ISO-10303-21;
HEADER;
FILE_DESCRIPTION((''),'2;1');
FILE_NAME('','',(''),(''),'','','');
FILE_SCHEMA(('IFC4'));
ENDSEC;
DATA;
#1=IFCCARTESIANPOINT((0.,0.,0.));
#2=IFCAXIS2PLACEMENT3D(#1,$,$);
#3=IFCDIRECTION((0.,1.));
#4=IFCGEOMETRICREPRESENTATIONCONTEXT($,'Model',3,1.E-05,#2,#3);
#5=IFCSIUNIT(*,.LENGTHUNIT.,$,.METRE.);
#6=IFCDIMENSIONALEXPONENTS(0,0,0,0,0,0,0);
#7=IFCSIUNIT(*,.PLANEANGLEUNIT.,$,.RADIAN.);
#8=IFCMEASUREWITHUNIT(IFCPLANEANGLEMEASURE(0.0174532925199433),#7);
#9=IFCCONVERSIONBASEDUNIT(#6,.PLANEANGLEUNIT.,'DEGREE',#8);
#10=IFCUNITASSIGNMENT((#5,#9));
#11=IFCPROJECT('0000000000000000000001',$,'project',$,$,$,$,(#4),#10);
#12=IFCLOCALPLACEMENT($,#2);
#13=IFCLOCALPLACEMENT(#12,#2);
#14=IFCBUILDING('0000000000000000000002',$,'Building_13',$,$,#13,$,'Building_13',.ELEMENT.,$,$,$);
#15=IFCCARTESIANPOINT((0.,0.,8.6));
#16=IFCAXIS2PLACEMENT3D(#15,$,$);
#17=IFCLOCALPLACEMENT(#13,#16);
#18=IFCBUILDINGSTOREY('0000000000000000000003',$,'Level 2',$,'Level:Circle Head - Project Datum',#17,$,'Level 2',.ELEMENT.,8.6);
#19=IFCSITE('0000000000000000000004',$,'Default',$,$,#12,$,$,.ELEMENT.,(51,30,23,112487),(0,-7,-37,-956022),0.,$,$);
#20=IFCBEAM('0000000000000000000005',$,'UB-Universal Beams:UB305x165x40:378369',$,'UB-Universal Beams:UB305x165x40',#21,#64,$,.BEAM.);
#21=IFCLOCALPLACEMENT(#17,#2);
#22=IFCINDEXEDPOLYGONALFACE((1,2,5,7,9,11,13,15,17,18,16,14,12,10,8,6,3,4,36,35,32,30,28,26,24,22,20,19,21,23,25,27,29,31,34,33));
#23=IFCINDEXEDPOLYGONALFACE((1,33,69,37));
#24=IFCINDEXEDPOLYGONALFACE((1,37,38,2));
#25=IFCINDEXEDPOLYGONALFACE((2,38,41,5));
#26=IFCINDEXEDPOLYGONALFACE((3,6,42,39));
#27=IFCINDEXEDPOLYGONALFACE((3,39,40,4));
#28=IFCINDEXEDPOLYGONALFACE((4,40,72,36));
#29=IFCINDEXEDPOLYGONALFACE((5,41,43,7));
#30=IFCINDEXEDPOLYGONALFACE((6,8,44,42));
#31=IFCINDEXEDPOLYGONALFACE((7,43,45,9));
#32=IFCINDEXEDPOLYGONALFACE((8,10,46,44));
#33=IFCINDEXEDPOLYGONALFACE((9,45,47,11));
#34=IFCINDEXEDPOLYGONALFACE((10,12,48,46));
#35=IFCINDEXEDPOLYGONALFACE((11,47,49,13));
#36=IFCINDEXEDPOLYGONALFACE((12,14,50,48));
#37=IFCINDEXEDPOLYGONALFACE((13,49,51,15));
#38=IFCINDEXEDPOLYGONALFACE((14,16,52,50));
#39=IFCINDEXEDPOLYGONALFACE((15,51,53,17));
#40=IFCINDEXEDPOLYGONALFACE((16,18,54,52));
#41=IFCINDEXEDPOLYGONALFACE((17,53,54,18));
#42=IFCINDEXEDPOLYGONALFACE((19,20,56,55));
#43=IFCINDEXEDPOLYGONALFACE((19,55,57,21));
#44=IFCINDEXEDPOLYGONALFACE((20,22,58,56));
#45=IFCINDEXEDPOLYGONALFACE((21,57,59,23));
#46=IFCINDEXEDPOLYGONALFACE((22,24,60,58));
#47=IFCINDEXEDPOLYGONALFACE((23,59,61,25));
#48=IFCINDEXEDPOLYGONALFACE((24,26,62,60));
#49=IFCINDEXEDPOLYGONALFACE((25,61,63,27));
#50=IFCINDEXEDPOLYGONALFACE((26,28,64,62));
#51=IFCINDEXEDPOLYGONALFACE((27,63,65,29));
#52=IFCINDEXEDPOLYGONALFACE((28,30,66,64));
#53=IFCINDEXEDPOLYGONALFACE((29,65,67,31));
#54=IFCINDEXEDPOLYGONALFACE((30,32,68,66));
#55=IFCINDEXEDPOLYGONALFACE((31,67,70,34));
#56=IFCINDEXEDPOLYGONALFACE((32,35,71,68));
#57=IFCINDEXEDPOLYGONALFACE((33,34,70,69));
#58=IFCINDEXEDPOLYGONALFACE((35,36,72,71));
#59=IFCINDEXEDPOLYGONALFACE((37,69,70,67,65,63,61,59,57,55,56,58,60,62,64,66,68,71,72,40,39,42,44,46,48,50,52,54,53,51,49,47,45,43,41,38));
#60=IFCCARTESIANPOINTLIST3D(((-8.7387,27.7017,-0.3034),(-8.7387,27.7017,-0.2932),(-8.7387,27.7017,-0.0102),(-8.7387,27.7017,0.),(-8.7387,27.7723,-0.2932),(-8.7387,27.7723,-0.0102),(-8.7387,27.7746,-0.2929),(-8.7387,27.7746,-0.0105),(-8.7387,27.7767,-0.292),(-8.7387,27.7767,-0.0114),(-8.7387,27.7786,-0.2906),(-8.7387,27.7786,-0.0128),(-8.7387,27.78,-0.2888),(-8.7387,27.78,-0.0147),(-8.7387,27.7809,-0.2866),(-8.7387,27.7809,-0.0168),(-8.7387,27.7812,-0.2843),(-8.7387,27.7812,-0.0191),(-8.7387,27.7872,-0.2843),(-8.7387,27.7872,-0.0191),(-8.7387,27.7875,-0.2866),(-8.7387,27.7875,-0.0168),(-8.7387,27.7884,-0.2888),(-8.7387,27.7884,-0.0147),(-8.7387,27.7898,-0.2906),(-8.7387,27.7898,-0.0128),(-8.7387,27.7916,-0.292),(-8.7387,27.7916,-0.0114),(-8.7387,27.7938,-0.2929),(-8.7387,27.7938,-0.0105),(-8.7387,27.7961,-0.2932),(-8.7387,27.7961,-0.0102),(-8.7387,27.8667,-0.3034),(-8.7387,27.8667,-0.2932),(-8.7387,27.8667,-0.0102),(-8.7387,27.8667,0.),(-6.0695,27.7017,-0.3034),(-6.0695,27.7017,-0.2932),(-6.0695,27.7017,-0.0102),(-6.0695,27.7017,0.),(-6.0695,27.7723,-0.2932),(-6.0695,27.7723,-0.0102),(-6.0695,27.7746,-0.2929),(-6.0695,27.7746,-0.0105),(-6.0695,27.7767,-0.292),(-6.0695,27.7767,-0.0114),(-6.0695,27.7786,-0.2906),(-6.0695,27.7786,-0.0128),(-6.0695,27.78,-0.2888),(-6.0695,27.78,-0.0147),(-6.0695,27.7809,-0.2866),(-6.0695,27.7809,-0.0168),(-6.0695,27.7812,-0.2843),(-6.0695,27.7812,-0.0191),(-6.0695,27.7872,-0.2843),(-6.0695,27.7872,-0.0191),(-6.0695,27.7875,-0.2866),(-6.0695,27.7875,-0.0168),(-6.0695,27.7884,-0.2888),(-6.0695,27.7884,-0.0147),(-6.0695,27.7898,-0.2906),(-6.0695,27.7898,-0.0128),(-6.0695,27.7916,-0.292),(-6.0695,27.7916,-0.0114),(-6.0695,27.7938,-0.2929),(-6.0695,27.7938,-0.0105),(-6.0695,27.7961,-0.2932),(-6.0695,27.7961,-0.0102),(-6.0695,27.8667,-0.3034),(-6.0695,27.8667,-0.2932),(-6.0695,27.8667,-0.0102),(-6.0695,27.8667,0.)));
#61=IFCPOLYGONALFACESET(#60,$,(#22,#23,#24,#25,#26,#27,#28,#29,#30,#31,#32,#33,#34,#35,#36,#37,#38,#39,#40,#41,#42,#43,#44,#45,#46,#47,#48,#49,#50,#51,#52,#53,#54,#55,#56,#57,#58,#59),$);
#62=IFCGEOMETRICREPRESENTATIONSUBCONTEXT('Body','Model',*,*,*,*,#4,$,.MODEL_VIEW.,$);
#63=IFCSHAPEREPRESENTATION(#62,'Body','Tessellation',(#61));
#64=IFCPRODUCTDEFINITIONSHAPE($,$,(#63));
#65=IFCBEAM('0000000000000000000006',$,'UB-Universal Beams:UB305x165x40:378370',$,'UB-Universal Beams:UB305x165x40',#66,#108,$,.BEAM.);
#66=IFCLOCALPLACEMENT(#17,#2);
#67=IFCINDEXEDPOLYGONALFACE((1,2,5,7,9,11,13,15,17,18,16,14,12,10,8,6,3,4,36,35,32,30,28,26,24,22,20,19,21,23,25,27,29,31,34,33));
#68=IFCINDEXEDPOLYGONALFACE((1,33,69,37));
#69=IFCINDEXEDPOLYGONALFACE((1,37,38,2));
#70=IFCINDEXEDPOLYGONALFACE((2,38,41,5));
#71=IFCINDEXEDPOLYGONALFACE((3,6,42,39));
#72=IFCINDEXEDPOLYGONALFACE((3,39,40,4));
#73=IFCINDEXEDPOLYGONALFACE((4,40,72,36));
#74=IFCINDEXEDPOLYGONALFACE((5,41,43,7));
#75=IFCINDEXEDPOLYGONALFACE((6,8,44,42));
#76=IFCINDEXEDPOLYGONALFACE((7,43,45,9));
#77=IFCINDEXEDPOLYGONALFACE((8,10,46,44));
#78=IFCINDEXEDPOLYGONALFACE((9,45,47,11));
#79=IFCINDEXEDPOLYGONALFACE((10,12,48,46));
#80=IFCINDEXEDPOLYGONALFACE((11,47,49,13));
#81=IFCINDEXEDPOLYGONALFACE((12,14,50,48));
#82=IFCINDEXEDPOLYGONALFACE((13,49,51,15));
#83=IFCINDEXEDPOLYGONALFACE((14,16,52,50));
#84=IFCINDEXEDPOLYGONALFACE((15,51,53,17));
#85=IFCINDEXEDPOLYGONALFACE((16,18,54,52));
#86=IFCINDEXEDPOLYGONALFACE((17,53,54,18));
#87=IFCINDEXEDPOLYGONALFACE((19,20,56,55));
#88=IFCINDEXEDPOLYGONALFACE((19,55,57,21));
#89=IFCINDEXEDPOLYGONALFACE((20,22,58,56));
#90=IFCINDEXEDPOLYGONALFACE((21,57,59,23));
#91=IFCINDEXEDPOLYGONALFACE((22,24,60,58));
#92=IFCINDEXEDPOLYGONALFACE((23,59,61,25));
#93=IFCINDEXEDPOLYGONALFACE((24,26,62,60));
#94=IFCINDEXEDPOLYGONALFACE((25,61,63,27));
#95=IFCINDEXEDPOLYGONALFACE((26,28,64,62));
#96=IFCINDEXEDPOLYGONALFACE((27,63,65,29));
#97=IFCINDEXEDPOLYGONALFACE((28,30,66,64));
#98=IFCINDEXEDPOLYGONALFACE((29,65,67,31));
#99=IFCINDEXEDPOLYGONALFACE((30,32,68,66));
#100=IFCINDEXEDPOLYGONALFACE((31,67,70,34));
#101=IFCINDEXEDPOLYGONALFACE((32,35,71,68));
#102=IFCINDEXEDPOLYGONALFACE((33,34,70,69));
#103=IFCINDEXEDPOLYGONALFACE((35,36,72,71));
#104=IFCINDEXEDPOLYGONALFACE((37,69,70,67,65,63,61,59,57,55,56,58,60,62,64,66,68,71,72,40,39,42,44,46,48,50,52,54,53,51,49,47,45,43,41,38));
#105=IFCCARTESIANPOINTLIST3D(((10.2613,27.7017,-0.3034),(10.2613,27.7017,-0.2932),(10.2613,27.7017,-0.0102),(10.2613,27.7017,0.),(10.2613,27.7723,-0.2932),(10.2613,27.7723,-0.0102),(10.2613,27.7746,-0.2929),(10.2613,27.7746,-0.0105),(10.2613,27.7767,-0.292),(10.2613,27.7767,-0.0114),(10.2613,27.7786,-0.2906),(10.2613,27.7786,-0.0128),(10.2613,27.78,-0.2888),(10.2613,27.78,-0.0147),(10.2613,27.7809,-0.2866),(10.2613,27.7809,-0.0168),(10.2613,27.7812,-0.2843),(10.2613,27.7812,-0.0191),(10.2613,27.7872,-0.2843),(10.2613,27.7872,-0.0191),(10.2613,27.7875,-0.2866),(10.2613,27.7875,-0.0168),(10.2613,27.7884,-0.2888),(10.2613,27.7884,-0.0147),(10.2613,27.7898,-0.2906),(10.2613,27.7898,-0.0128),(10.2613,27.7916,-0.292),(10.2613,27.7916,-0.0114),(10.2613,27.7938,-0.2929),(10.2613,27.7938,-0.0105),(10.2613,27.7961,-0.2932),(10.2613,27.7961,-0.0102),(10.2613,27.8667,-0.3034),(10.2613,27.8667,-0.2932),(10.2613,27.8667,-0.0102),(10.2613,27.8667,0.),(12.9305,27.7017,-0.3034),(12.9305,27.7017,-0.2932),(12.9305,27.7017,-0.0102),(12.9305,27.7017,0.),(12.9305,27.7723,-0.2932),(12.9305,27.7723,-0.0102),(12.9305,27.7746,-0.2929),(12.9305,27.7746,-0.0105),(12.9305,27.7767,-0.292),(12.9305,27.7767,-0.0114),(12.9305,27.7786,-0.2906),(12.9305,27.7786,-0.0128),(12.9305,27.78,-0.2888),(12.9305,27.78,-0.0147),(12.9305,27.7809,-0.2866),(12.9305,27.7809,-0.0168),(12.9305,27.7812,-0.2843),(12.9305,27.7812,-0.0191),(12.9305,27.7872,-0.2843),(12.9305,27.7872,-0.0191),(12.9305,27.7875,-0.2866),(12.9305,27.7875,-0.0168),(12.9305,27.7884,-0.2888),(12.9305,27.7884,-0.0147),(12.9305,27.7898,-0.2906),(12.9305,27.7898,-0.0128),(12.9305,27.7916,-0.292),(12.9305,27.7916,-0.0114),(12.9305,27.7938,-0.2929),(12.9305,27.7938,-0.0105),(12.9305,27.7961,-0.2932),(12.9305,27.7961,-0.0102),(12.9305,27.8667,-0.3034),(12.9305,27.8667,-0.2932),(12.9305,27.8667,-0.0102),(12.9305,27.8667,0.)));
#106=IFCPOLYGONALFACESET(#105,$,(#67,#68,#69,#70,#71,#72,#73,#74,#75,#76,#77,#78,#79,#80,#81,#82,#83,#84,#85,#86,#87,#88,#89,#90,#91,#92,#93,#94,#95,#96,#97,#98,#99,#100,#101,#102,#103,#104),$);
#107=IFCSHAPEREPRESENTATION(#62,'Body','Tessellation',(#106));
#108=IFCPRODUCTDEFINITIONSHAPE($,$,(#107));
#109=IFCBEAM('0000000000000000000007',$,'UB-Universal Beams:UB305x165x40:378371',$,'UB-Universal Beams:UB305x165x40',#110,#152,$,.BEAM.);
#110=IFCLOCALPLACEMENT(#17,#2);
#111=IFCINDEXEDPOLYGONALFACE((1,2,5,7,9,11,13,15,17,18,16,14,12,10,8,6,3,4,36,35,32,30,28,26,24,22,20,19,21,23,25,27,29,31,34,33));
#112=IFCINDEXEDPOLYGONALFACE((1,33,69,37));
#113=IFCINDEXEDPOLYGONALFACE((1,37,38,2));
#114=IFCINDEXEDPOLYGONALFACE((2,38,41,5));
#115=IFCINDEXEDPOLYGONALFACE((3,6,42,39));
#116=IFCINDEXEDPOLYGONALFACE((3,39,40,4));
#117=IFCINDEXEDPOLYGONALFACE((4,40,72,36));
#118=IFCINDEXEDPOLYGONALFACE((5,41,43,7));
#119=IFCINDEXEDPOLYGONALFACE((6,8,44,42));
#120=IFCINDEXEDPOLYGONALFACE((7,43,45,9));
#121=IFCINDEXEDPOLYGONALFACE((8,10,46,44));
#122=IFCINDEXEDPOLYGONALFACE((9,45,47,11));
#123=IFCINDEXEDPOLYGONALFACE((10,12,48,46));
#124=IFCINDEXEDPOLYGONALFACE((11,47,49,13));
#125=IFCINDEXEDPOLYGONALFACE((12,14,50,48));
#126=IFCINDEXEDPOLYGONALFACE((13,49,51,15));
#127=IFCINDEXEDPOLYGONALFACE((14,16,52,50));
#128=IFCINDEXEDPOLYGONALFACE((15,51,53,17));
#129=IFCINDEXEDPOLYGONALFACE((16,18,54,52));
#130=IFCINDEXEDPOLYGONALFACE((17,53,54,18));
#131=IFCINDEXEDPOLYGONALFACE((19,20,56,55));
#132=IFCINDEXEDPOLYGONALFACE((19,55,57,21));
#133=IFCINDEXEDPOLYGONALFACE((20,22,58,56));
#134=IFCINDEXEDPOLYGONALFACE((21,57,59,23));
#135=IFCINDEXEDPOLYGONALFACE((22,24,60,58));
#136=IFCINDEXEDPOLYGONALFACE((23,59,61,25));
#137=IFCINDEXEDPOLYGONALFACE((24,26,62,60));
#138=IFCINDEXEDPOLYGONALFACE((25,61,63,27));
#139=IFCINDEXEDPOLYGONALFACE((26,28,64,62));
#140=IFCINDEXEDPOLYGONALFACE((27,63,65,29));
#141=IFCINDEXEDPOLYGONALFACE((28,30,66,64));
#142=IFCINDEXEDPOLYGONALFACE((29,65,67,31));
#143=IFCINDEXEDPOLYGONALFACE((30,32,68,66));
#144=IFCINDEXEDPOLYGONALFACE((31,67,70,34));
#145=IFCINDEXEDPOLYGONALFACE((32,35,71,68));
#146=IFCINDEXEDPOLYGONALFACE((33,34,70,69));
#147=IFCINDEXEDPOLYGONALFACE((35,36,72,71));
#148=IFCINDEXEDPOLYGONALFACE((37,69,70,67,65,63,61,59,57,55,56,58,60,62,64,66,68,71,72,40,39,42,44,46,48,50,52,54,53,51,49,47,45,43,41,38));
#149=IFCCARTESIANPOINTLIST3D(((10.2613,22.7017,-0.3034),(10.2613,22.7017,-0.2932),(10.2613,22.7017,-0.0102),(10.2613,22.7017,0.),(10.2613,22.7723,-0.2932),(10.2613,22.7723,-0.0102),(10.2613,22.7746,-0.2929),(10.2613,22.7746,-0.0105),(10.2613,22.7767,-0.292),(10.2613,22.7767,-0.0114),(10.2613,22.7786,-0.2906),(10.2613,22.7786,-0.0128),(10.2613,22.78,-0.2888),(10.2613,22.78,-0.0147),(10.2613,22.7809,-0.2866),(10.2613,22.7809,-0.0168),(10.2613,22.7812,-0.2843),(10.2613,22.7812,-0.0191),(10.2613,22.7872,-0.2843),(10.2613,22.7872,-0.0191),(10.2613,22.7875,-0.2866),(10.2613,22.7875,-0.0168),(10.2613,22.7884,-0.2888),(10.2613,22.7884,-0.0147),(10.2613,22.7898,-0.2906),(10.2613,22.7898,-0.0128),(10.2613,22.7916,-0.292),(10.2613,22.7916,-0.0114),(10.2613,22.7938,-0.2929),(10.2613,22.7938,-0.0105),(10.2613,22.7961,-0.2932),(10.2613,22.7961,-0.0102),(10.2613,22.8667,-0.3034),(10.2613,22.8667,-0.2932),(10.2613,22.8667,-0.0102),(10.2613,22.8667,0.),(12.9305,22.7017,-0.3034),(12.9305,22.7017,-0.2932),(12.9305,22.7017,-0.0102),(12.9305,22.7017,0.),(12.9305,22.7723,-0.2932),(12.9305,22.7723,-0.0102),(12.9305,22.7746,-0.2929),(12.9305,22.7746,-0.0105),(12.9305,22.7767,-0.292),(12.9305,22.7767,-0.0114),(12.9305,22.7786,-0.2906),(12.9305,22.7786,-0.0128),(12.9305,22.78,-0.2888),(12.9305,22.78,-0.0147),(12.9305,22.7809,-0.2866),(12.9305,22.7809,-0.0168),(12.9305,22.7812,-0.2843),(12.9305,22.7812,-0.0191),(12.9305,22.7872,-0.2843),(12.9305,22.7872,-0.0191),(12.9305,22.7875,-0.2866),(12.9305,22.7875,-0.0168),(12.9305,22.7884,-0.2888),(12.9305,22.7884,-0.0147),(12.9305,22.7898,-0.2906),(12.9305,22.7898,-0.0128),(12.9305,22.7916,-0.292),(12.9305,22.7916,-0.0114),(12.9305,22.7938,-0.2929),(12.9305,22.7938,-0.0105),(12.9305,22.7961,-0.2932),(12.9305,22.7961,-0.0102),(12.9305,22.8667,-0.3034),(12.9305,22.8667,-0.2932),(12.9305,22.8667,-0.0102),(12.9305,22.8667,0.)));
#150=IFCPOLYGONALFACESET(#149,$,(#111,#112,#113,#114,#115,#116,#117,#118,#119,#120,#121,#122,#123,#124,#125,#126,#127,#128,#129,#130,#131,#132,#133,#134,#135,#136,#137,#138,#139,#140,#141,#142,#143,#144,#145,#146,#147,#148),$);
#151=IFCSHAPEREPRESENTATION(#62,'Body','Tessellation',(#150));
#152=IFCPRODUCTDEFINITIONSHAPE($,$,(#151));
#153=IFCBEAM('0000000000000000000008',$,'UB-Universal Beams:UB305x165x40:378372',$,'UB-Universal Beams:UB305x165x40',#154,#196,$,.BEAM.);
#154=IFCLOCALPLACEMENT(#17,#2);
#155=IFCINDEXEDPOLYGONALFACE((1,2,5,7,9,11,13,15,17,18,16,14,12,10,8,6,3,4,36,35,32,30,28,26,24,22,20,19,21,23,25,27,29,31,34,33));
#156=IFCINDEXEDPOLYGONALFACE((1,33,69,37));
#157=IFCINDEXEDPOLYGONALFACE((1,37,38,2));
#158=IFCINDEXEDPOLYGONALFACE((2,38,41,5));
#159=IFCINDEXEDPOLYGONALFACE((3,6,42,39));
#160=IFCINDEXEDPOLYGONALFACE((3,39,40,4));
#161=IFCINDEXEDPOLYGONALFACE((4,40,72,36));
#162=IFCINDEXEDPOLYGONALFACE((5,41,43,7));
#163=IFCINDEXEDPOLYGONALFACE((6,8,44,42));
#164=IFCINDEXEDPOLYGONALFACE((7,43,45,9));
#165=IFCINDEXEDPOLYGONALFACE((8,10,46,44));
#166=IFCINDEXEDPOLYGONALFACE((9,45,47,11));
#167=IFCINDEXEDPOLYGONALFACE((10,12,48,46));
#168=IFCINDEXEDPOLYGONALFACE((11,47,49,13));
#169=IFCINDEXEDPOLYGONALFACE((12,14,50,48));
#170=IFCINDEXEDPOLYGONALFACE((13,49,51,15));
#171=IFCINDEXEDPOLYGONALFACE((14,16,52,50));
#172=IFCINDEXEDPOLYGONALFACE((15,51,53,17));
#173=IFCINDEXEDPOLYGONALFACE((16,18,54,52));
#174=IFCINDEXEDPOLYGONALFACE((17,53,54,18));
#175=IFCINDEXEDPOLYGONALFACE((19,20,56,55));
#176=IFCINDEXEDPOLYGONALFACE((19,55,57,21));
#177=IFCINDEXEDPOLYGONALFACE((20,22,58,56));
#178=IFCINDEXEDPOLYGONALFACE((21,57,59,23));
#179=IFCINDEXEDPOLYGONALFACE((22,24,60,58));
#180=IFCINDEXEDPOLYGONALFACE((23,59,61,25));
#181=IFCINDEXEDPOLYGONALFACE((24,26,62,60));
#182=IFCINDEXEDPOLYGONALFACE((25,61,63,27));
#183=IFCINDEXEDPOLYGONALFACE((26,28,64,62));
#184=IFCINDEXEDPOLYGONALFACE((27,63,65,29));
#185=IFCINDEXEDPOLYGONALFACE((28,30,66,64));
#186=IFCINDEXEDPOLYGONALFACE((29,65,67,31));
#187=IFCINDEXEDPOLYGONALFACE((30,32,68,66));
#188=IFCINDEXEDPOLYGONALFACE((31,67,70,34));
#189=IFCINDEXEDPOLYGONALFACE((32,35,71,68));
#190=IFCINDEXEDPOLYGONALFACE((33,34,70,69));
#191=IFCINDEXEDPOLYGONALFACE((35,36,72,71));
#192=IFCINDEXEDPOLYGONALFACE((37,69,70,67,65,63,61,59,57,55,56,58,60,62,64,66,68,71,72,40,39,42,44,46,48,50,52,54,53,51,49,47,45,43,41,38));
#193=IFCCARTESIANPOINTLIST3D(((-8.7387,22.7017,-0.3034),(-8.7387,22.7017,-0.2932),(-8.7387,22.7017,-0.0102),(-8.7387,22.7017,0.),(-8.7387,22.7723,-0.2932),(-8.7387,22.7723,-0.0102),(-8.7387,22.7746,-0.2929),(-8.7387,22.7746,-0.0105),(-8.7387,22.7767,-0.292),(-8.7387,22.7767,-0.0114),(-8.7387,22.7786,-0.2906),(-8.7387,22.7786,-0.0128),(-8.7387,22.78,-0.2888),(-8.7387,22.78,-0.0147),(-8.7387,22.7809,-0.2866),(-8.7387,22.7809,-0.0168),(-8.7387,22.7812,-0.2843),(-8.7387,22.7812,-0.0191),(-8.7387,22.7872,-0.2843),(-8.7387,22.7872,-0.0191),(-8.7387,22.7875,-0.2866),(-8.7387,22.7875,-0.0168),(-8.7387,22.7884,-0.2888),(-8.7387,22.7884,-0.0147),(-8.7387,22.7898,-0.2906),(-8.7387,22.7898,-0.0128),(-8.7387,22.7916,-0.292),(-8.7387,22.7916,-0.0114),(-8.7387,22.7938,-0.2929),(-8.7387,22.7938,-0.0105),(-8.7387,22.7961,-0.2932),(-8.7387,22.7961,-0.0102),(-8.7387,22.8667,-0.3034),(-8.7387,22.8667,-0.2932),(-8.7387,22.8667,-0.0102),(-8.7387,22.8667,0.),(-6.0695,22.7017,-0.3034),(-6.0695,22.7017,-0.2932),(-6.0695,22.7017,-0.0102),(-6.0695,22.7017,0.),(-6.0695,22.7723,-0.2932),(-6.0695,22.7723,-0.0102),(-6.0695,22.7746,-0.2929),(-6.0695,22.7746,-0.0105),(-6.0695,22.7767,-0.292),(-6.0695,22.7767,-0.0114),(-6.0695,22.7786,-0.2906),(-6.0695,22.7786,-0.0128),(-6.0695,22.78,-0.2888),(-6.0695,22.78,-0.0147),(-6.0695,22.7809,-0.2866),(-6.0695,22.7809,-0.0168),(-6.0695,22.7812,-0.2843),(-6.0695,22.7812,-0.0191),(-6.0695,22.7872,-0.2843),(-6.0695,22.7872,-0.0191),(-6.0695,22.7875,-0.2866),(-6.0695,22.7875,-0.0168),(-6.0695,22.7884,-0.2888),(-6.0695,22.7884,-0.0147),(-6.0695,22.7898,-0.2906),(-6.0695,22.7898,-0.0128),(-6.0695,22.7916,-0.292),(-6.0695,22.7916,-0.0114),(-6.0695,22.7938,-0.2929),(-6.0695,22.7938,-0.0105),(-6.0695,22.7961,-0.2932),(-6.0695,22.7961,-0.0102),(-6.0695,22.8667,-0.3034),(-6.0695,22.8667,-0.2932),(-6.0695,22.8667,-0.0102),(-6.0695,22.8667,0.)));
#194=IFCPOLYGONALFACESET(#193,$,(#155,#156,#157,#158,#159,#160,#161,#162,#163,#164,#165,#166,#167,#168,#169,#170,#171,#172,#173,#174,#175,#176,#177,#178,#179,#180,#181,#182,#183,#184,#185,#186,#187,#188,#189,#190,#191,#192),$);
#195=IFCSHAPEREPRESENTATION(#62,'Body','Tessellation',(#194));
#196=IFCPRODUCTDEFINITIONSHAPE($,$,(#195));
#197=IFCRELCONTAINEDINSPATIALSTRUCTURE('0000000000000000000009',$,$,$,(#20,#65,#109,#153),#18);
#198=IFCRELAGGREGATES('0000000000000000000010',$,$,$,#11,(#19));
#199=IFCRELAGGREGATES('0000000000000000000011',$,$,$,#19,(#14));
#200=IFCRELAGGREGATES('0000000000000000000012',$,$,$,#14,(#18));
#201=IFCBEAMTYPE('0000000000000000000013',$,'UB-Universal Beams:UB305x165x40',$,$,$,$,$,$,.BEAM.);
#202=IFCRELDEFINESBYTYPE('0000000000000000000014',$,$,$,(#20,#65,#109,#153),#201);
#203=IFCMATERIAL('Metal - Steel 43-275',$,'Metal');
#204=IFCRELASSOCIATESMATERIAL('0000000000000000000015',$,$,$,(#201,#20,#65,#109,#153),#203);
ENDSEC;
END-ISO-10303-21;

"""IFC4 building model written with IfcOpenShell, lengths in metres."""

from ifc_helpers import new_model, entity, si_unit, converted_unit, direction, frame, origin, place, context, subcontext, project, spatial, line, arc, indexed_curve, outline, extrude, source, transform, mapped, material, type_object, type_shapes, element, save


model = new_model("IFC4")

# Units and contexts
model_context = context("Model", 3, precision=1e-05, world=origin(), true_north=direction((0.0, 1.0)))
body_context = subcontext(model_context, "Body", "Model", "MODEL_VIEW")
ifc_project = project(units=[si_unit("LENGTHUNIT", "METRE"), converted_unit("PLANEANGLEUNIT", "DEGREE", entity("IfcPlaneAngleMeasure", 0.0174532925199433), si_unit("PLANEANGLEUNIT", "RADIAN"), dimensions=[0, 0, 0, 0, 0, 0, 0])], contexts=[model_context])

# Site, building, storey
site_placement = place(None, origin())
site = spatial("IfcSite", under=ifc_project, at=site_placement, Name="Default", CompositionType="ELEMENT", RefLatitude=(51, 30, 23, 112487), RefLongitude=(0, -7, -37, -956022), RefElevation=0.0)
building_placement = place(site_placement, origin())
building = spatial("IfcBuilding", under=site, at=building_placement, Name="Building_13", LongName="Building_13", CompositionType="ELEMENT")
storey_placement = place(building_placement, frame((0.0, 0.0, 8.6)))
storey = spatial("IfcBuildingStorey", under=building, at=storey_placement, Name="Level 2", ObjectType="Level:Circle Head - Project Datum", LongName="Level 2", CompositionType="ELEMENT", Elevation=8.6)

# Beams
ifc_material_1 = material(Name="Metal - Steel 43-275", Category="Metal")
beam_type_1 = type_object("IfcBeamType", Name="UB-Universal Beams:UB305x165x40", PredefinedType="BEAM", material=ifc_material_1)
shared_shape_1 = source(origin(), body_context, "Body", "SweptSolid", [
    extrude(outline(indexed_curve([(-0.0825, -0.1415), (-0.0825, -0.1517), (0.0825, -0.1517), (0.0825, -0.1415), (0.0119, -0.1415), (0.0056, -0.1389), (0.003, -0.1326), (0.003, 0.1326), (0.0056, 0.1389), (0.0119, 0.1415), (0.0825, 0.1415), (0.0825, 0.1517), (-0.0825, 0.1517), (-0.0825, 0.1415), (-0.0119, 0.1415), (-0.0056, 0.1389), (-0.003, 0.1326), (-0.003, -0.1326), (-0.0056, -0.1389), (-0.0119, -0.1415)], segments=[line(1, 2, 3, 4, 5), arc(5, 6, 7), line(7, 8), arc(8, 9, 10), line(10, 11, 12, 13, 14, 15), arc(15, 16, 17), line(17, 18), arc(18, 19, 20), line(20, 1)], self_intersect=False)), frame((-1.3346, 0.0, 0.0), z_axis=(-1.0, 0.0, 0.0), x_axis=(0.0, -1.0, 0.0)), (0.0, 0.0, -1.0), 2.6692),
])
type_shapes(beam_type_1, [shared_shape_1])
for number, where, name in (
    (1, (-7.4041, 27.7842, -0.1517), "UB-Universal Beams:UB305x165x40:378369"),
    (2, (11.5959, 27.7842, -0.1517), "UB-Universal Beams:UB305x165x40:378370"),
):
    element("IfcBeam", number, at=place(storey_placement, frame(where)), inside=storey, type_object=beam_type_1, material=ifc_material_1, Name=name, ObjectType="UB-Universal Beams:UB305x165x40", PredefinedType="BEAM", context=body_context, shape_type="MappedRepresentation", body=[
        mapped(shared_shape_1, transform((0.0, 0.0, 0.0), scale=1.0)),
    ])
for number, where, z_axis, x_axis, name in (
    (3, (11.5959, 22.7842, -0.1517), (0.0, 0.0, 1.0), (-1.0, 0.0, 0.0), "UB-Universal Beams:UB305x165x40:378371"),
    (4, (-7.4041, 22.7842, -0.1517), (0.0, 0.0, 1.0), (-1.0, 0.0, 0.0), "UB-Universal Beams:UB305x165x40:378372"),
):
    element("IfcBeam", number, at=place(storey_placement, frame(where, z_axis=z_axis, x_axis=x_axis)), inside=storey, type_object=beam_type_1, material=ifc_material_1, Name=name, ObjectType="UB-Universal Beams:UB305x165x40", PredefinedType="BEAM", context=body_context, shape_type="MappedRepresentation", body=[
        mapped(shared_shape_1, transform((0.0, 0.0, 0.0), scale=1.0)),
    ])

save(model, "model.ifc")
